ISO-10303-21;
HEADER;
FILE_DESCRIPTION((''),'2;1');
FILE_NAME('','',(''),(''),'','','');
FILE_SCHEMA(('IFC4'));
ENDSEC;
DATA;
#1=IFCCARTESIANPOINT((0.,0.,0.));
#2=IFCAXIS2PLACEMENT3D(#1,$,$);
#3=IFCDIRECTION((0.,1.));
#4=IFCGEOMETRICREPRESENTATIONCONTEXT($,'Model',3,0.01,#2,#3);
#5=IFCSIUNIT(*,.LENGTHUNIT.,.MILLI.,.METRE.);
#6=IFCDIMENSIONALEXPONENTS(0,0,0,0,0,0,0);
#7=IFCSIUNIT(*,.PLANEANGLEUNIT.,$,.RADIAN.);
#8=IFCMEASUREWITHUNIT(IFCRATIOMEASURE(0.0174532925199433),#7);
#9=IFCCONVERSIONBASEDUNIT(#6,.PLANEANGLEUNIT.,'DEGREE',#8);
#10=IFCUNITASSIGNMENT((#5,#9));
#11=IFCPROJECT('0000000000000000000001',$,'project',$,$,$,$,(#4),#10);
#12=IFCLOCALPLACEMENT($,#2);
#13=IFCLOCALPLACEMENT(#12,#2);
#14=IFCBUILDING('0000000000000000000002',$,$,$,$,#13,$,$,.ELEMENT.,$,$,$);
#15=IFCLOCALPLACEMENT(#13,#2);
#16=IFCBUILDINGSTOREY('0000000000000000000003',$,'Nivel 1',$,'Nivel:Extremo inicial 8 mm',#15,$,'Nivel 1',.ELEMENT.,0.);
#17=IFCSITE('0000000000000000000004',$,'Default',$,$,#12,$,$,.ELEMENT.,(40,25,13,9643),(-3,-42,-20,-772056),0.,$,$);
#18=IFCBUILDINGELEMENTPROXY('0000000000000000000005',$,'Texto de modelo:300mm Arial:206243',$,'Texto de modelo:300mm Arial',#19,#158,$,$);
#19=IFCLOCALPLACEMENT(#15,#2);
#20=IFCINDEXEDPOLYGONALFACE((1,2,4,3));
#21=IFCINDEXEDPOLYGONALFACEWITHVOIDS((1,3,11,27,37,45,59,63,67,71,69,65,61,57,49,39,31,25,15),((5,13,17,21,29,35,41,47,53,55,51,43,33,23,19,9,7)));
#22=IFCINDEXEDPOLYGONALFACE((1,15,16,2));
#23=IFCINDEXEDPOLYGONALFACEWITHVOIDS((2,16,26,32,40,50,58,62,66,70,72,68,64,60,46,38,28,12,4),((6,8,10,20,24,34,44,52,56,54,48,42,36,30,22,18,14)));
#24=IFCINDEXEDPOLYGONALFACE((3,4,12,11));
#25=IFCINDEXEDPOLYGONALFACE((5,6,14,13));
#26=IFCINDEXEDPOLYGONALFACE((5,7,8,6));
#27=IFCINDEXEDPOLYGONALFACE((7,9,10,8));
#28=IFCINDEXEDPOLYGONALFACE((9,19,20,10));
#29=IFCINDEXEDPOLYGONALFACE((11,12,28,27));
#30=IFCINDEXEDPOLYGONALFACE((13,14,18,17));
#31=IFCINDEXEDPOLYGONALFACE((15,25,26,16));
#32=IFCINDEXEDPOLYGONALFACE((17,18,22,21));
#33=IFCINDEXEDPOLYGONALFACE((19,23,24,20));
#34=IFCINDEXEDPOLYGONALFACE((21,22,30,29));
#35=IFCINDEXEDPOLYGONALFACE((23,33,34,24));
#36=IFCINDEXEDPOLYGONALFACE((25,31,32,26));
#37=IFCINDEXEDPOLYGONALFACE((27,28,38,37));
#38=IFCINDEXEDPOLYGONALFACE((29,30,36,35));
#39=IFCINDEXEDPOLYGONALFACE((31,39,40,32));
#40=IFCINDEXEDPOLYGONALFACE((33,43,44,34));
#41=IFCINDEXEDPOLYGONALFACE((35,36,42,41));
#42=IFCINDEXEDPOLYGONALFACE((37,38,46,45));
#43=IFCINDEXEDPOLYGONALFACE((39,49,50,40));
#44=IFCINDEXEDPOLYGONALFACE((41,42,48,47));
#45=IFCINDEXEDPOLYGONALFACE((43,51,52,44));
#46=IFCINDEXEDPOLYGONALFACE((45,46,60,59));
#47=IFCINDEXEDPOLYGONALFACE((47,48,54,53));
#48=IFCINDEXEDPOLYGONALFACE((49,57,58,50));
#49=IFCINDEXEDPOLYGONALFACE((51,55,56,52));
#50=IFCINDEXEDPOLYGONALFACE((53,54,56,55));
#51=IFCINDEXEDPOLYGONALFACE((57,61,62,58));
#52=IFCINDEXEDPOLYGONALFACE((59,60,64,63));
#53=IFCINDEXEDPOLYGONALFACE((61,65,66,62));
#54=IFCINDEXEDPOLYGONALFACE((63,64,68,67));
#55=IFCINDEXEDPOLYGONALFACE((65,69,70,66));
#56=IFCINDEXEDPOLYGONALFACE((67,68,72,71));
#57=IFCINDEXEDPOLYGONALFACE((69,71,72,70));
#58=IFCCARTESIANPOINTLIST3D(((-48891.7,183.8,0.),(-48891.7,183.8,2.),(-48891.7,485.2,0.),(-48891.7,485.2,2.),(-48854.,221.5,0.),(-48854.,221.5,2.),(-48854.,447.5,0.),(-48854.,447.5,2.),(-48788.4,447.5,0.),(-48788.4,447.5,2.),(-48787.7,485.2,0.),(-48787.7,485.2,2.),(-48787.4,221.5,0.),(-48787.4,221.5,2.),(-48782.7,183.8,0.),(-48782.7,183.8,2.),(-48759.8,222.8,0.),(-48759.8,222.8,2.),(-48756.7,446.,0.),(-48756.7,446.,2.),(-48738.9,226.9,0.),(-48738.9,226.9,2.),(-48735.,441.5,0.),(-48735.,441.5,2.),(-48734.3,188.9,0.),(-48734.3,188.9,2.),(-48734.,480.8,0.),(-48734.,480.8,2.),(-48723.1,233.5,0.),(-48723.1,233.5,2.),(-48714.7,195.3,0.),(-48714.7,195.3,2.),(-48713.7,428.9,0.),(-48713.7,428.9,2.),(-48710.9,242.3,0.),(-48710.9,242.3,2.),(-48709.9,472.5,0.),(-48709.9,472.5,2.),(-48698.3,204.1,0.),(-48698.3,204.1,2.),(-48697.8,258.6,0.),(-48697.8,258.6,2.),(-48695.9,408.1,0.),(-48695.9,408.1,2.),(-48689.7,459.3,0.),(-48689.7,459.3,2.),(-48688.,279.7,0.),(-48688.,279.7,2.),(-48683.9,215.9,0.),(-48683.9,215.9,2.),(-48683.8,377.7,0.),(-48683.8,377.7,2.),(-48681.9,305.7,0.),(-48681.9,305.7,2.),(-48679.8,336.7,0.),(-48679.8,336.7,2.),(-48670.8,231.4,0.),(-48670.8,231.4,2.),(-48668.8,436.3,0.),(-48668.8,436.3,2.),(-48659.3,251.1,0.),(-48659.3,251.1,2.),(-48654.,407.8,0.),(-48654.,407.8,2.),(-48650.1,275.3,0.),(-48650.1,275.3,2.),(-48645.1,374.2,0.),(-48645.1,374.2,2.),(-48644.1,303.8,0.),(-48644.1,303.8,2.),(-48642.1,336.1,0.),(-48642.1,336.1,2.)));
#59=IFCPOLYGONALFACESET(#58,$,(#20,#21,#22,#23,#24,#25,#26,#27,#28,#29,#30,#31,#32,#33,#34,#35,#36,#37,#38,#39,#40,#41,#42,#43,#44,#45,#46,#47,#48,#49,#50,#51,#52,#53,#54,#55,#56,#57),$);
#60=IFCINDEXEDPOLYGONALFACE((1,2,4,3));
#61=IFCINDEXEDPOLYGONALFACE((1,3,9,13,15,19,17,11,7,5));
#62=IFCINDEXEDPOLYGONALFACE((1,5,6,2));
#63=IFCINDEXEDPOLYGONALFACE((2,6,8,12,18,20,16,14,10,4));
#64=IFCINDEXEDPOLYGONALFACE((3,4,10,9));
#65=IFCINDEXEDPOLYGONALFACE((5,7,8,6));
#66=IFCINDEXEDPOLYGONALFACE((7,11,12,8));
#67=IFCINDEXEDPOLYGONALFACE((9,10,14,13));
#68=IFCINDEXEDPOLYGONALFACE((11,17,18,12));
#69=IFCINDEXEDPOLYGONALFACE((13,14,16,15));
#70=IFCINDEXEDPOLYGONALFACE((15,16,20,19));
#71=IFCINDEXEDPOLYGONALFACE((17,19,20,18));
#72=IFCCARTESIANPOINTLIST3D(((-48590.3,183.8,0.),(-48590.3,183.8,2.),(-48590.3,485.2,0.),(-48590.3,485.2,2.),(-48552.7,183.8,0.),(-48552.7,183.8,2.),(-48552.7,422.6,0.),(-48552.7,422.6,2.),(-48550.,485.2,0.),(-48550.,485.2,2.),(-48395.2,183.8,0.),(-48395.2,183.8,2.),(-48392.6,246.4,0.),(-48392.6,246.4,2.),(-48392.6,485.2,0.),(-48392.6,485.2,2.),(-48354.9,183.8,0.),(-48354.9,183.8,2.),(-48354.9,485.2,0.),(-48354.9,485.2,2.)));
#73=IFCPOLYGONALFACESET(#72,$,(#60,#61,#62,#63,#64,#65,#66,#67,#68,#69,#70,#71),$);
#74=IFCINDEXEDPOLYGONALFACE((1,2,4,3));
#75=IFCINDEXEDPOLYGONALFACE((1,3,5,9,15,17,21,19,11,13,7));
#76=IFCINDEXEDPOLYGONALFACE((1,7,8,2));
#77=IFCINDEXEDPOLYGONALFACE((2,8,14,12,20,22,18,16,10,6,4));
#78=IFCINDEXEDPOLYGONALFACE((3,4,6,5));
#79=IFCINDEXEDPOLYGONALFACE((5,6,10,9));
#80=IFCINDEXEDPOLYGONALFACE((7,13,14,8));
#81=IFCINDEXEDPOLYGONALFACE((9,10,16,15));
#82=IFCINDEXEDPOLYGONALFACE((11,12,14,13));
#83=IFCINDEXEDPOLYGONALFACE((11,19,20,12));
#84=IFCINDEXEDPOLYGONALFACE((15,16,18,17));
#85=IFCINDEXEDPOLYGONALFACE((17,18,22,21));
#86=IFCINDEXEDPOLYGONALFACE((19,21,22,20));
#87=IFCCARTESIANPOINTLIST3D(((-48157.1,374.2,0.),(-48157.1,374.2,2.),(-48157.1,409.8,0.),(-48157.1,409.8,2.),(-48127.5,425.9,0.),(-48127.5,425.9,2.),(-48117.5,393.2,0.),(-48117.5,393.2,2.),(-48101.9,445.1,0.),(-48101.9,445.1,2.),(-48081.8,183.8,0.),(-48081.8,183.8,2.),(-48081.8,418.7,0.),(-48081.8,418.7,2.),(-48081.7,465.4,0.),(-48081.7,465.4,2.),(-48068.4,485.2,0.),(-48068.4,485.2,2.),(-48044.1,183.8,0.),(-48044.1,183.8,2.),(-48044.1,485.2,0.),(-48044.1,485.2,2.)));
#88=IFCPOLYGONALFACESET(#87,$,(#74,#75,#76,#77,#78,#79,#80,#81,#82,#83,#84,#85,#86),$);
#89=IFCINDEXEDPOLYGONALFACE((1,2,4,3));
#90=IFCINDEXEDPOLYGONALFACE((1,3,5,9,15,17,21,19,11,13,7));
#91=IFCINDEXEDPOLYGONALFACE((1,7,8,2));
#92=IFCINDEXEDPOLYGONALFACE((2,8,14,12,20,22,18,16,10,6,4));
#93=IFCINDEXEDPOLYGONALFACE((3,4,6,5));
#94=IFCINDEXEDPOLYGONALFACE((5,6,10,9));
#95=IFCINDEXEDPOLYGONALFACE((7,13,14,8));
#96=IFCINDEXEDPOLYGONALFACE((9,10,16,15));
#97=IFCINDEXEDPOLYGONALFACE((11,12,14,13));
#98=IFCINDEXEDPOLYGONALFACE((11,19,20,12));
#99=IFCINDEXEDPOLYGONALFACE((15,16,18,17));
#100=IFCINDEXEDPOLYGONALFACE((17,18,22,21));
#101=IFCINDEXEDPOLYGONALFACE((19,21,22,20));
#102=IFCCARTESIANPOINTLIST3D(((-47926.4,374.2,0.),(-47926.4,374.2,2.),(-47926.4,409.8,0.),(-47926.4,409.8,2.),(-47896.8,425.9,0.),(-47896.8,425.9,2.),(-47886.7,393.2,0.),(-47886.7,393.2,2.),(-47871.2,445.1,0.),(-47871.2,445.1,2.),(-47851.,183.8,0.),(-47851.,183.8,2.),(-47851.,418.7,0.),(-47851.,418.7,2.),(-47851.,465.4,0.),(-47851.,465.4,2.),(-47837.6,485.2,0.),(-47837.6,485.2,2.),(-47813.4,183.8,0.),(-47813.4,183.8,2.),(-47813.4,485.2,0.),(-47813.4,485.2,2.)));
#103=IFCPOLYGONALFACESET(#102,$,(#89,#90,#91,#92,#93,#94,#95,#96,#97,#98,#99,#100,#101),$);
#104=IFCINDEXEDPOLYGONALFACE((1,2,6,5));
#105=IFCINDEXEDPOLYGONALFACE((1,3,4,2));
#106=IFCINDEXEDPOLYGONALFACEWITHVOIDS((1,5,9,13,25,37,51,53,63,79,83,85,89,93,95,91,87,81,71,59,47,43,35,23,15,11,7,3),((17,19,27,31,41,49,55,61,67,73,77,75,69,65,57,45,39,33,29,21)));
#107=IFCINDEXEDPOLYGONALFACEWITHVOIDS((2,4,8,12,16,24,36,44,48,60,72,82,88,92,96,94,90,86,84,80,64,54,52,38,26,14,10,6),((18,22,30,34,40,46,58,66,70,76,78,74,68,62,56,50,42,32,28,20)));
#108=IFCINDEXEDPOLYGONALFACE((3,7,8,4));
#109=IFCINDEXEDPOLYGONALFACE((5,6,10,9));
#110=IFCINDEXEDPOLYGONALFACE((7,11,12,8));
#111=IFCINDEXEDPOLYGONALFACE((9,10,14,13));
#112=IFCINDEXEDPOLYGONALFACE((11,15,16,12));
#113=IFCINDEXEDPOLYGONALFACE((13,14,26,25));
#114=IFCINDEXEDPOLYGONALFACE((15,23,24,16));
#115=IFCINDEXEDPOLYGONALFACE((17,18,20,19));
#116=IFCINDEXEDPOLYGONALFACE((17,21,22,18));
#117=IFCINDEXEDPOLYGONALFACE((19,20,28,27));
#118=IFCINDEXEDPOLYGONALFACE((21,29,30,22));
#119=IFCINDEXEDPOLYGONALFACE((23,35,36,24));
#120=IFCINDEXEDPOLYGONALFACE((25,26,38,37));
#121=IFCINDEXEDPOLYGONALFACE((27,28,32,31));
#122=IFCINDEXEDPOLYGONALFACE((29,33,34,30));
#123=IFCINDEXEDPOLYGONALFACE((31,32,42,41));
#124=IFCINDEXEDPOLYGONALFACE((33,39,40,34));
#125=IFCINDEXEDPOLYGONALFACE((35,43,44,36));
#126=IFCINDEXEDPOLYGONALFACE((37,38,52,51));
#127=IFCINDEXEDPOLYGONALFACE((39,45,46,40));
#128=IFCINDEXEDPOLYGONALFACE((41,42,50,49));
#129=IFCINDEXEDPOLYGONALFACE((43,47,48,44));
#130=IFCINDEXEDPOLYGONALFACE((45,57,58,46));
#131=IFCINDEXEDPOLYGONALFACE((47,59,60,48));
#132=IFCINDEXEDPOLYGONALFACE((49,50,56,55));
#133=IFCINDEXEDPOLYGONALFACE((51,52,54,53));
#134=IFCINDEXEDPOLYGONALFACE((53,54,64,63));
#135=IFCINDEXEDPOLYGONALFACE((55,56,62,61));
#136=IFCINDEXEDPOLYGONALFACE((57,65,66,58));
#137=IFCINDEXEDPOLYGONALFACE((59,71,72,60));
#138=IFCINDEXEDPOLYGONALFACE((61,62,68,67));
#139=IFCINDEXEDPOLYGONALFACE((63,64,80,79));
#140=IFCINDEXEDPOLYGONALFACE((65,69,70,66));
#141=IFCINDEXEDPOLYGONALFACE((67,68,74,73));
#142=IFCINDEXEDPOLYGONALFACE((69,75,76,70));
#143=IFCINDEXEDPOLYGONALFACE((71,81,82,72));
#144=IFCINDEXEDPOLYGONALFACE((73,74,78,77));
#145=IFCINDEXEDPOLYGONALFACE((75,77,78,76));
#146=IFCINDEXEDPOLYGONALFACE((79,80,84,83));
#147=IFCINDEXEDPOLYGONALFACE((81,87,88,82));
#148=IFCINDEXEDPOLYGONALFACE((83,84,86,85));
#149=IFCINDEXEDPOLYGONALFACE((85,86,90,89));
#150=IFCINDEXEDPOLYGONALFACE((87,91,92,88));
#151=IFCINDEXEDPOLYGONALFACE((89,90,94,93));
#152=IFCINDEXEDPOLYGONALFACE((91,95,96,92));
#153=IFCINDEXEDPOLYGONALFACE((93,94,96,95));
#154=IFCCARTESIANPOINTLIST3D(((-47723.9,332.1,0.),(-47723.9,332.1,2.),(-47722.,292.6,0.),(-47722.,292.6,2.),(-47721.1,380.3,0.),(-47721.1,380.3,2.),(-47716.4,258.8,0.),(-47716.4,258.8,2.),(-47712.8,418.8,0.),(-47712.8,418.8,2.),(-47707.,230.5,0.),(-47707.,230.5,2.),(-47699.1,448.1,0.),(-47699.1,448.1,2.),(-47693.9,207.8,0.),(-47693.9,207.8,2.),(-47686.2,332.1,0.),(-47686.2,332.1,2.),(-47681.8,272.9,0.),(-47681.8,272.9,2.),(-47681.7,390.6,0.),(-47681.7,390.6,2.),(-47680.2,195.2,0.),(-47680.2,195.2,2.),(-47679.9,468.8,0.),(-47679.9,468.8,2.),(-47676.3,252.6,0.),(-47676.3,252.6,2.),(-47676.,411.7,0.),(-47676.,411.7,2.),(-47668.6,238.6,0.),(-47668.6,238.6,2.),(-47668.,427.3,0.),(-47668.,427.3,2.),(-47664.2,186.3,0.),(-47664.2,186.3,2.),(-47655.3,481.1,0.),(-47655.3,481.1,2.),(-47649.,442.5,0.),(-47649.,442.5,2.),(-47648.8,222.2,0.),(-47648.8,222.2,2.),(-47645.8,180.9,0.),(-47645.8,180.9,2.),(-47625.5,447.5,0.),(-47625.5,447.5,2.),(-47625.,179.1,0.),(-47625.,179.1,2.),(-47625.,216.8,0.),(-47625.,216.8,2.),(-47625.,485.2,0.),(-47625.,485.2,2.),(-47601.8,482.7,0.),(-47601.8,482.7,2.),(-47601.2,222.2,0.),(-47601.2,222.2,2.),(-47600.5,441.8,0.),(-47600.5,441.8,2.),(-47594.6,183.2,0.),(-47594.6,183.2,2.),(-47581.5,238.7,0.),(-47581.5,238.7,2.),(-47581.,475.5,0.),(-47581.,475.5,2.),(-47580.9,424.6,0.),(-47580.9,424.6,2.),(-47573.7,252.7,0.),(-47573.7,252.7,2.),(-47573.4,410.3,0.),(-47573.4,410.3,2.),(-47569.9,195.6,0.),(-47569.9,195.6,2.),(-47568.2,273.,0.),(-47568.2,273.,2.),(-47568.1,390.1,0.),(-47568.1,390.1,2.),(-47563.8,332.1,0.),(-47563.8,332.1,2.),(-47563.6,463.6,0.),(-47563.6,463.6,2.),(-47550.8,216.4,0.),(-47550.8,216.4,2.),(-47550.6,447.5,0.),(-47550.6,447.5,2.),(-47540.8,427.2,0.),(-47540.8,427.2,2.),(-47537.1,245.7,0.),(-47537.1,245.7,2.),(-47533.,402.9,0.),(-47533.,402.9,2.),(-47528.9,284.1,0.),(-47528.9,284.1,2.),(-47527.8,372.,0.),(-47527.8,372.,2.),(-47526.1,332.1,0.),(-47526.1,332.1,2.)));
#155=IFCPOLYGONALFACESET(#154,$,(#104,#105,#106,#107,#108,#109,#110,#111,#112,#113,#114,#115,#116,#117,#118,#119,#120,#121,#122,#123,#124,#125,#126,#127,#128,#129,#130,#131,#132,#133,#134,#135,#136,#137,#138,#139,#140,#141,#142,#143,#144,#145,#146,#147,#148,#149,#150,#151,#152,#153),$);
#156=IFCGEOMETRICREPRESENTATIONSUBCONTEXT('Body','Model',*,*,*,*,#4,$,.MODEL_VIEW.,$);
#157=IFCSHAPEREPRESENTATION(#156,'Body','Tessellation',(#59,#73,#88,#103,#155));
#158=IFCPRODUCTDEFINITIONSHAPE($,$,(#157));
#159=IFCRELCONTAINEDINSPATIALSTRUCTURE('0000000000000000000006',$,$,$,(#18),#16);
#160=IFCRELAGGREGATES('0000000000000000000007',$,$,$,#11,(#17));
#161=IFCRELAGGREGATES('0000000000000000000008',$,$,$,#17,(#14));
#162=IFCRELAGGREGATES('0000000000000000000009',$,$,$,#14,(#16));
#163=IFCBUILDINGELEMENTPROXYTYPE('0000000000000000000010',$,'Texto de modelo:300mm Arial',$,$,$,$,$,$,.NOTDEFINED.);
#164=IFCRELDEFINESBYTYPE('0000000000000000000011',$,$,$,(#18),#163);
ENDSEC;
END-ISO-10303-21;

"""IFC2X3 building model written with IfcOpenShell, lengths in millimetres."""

from ifc_helpers import new_model, entity, si_unit, converted_unit, direction, frame, origin, place, context, subcontext, project, spatial, polyline, outline, extrude, type_object, element, save


model = new_model("IFC2X3")

# Units and contexts
model_context = context("Model", 3, precision=0.01, world=origin(), true_north=direction((0.0, 1.0)))
body_context = subcontext(model_context, "Body", "Model", "MODEL_VIEW")
ifc_project = project(units=[si_unit("LENGTHUNIT", "METRE", prefix="MILLI"), converted_unit("PLANEANGLEUNIT", "DEGREE", entity("IfcRatioMeasure", 0.0174532925199433), si_unit("PLANEANGLEUNIT", "RADIAN"), dimensions=[0, 0, 0, 0, 0, 0, 0])], contexts=[model_context])

# Site, building, storey
site_placement = place(None, origin())
site = spatial("IfcSite", under=ifc_project, at=site_placement, Name="Default", CompositionType="ELEMENT", RefLatitude=(40, 25, 13, 9643), RefLongitude=(-3, -42, -20, -772056), RefElevation=0.0)
building_placement = place(site_placement, origin())
building = spatial("IfcBuilding", under=site, at=building_placement, CompositionType="ELEMENT")
storey_placement = place(building_placement, origin())
storey = spatial("IfcBuildingStorey", under=building, at=storey_placement, Name="Nivel 1", ObjectType="Nivel:Extremo inicial 8 mm", LongName="Nivel 1", CompositionType="ELEMENT", Elevation=0.0)

# Building element proxy
building_element_proxy_type_1 = type_object("IfcBuildingElementProxyType", Name="Texto de modelo:300mm Arial", PredefinedType="NOTDEFINED")
proxy_1_placement = place(storey_placement, frame((-48891.7, 179.1, 0.0)))
element("IfcBuildingElementProxy", 1, at=proxy_1_placement, inside=storey, type_object=building_element_proxy_type_1, Name="Texto de modelo:300mm Arial:206243", ObjectType="Texto de modelo:300mm Arial", context=body_context, shape_type="SweptSolid", body=[
    extrude(outline(polyline([(-178.4, -141.0), (-69.4, -141.0), (-21.0, -135.8), (-1.4, -129.5), (15.0, -120.7), (29.4, -108.9), (42.6, -93.4), (54.0, -73.7), (63.2, -49.5), (69.2, -21.0), (71.2, 11.3), (68.2, 49.4), (59.3, 83.0), (44.5, 111.5), (23.7, 134.5), (3.4, 147.7), (-20.6, 156.1), (-74.4, 160.4), (-178.4, 160.4), (-178.4, -141.0)]), holes=[polyline([(-140.7, -103.3), (-140.7, 122.7), (-75.1, 122.7), (-43.3, 121.2), (-21.7, 116.7), (-0.4, 104.1), (17.4, 83.3), (29.5, 53.0), (33.5, 11.9), (31.5, -19.1), (25.3, -45.1), (15.5, -66.2), (2.4, -82.5), (-9.8, -91.3), (-25.6, -97.9), (-46.5, -101.9), (-74.1, -103.3), (-140.7, -103.3)])]), frame((178.4, 145.7, 0.0)), (0.0, 0.0, 1.0), 2.0),
    extrude(outline(polyline([(-117.7, -150.7), (-80.1, -150.7), (-80.1, 88.1), (77.4, -150.7), (117.7, -150.7), (117.7, 150.7), (80.1, 150.7), (80.1, -88.1), (-77.4, 150.7), (-117.7, 150.7), (-117.7, -150.7)])), frame((419.1, 155.4, 0.0)), (0.0, 0.0, 1.0), 2.0),
    extrude(outline(polyline([(-204.4, -52.5), (97.0, -52.5), (97.0, -28.2), (77.2, -14.9), (56.9, 5.3), (37.7, 30.9), (21.6, 60.5), (-14.0, 60.5), (5.0, 20.8), (30.4, -14.9), (-204.4, -14.9), (-204.4, -52.5)])), frame((795.1, 209.1, 0.0), z_axis=(0.0, 0.0, 1.0), x_axis=(0.0, 1.0, 0.0)), (0.0, 0.0, 1.0), 2.0),
    extrude(outline(polyline([(-204.4, -52.5), (97.0, -52.5), (97.0, -28.2), (77.2, -14.9), (56.9, 5.3), (37.7, 30.9), (21.6, 60.5), (-14.0, 60.5), (5.0, 20.8), (30.4, -14.9), (-204.4, -14.9), (-204.4, -52.5)])), frame((1025.8, 209.1, 0.0), z_axis=(0.0, 0.0, 1.0), x_axis=(0.0, 1.0, 0.0)), (0.0, 0.0, 1.0), 2.0),
    extrude(outline(polyline([(-5.6, -99.5), (33.9, -99.5), (68.0, -95.5), (96.7, -87.5), (120.0, -75.5), (133.2, -62.4), (142.9, -46.8), (149.1, -28.7), (151.9, -8.0), (149.2, 22.6), (138.0, 47.8), (118.2, 67.9), (89.5, 82.9), (51.6, 93.0), (3.8, 98.0), (-36.2, 98.2), (-67.3, 94.5), (-91.9, 87.9), (-112.6, 79.0), (-129.4, 66.8), (-142.0, 50.0), (-150.3, 29.6), (-153.8, 6.5), (-151.2, -23.9), (-140.1, -49.1), (-120.3, -69.2), (-91.7, -84.4), (-53.6, -94.5), (-5.6, -99.5)]), holes=[polyline([(-3.9, -61.9), (-62.1, -54.6), (-82.9, -47.9), (-98.1, -39.2), (-112.3, -19.5), (-116.2, 4.3), (-109.3, 28.9), (-91.2, 47.7), (-76.5, 54.5), (-56.1, 58.9), (1.9, 60.4), (60.8, 53.2), (80.8, 46.7), (94.5, 38.3), (109.9, 17.8), (114.3, -6.3), (107.7, -29.8), (90.4, -48.7), (76.0, -55.8), (55.5, -60.3), (-3.9, -61.9)])]), frame((1267.5, 152.1, 0.0), z_axis=(0.0, 0.0, 1.0), x_axis=(0.047515, -0.998871, 0.0)), (0.0, 0.0, 1.0), 2.0),
])

save(model, "model.ifc")
